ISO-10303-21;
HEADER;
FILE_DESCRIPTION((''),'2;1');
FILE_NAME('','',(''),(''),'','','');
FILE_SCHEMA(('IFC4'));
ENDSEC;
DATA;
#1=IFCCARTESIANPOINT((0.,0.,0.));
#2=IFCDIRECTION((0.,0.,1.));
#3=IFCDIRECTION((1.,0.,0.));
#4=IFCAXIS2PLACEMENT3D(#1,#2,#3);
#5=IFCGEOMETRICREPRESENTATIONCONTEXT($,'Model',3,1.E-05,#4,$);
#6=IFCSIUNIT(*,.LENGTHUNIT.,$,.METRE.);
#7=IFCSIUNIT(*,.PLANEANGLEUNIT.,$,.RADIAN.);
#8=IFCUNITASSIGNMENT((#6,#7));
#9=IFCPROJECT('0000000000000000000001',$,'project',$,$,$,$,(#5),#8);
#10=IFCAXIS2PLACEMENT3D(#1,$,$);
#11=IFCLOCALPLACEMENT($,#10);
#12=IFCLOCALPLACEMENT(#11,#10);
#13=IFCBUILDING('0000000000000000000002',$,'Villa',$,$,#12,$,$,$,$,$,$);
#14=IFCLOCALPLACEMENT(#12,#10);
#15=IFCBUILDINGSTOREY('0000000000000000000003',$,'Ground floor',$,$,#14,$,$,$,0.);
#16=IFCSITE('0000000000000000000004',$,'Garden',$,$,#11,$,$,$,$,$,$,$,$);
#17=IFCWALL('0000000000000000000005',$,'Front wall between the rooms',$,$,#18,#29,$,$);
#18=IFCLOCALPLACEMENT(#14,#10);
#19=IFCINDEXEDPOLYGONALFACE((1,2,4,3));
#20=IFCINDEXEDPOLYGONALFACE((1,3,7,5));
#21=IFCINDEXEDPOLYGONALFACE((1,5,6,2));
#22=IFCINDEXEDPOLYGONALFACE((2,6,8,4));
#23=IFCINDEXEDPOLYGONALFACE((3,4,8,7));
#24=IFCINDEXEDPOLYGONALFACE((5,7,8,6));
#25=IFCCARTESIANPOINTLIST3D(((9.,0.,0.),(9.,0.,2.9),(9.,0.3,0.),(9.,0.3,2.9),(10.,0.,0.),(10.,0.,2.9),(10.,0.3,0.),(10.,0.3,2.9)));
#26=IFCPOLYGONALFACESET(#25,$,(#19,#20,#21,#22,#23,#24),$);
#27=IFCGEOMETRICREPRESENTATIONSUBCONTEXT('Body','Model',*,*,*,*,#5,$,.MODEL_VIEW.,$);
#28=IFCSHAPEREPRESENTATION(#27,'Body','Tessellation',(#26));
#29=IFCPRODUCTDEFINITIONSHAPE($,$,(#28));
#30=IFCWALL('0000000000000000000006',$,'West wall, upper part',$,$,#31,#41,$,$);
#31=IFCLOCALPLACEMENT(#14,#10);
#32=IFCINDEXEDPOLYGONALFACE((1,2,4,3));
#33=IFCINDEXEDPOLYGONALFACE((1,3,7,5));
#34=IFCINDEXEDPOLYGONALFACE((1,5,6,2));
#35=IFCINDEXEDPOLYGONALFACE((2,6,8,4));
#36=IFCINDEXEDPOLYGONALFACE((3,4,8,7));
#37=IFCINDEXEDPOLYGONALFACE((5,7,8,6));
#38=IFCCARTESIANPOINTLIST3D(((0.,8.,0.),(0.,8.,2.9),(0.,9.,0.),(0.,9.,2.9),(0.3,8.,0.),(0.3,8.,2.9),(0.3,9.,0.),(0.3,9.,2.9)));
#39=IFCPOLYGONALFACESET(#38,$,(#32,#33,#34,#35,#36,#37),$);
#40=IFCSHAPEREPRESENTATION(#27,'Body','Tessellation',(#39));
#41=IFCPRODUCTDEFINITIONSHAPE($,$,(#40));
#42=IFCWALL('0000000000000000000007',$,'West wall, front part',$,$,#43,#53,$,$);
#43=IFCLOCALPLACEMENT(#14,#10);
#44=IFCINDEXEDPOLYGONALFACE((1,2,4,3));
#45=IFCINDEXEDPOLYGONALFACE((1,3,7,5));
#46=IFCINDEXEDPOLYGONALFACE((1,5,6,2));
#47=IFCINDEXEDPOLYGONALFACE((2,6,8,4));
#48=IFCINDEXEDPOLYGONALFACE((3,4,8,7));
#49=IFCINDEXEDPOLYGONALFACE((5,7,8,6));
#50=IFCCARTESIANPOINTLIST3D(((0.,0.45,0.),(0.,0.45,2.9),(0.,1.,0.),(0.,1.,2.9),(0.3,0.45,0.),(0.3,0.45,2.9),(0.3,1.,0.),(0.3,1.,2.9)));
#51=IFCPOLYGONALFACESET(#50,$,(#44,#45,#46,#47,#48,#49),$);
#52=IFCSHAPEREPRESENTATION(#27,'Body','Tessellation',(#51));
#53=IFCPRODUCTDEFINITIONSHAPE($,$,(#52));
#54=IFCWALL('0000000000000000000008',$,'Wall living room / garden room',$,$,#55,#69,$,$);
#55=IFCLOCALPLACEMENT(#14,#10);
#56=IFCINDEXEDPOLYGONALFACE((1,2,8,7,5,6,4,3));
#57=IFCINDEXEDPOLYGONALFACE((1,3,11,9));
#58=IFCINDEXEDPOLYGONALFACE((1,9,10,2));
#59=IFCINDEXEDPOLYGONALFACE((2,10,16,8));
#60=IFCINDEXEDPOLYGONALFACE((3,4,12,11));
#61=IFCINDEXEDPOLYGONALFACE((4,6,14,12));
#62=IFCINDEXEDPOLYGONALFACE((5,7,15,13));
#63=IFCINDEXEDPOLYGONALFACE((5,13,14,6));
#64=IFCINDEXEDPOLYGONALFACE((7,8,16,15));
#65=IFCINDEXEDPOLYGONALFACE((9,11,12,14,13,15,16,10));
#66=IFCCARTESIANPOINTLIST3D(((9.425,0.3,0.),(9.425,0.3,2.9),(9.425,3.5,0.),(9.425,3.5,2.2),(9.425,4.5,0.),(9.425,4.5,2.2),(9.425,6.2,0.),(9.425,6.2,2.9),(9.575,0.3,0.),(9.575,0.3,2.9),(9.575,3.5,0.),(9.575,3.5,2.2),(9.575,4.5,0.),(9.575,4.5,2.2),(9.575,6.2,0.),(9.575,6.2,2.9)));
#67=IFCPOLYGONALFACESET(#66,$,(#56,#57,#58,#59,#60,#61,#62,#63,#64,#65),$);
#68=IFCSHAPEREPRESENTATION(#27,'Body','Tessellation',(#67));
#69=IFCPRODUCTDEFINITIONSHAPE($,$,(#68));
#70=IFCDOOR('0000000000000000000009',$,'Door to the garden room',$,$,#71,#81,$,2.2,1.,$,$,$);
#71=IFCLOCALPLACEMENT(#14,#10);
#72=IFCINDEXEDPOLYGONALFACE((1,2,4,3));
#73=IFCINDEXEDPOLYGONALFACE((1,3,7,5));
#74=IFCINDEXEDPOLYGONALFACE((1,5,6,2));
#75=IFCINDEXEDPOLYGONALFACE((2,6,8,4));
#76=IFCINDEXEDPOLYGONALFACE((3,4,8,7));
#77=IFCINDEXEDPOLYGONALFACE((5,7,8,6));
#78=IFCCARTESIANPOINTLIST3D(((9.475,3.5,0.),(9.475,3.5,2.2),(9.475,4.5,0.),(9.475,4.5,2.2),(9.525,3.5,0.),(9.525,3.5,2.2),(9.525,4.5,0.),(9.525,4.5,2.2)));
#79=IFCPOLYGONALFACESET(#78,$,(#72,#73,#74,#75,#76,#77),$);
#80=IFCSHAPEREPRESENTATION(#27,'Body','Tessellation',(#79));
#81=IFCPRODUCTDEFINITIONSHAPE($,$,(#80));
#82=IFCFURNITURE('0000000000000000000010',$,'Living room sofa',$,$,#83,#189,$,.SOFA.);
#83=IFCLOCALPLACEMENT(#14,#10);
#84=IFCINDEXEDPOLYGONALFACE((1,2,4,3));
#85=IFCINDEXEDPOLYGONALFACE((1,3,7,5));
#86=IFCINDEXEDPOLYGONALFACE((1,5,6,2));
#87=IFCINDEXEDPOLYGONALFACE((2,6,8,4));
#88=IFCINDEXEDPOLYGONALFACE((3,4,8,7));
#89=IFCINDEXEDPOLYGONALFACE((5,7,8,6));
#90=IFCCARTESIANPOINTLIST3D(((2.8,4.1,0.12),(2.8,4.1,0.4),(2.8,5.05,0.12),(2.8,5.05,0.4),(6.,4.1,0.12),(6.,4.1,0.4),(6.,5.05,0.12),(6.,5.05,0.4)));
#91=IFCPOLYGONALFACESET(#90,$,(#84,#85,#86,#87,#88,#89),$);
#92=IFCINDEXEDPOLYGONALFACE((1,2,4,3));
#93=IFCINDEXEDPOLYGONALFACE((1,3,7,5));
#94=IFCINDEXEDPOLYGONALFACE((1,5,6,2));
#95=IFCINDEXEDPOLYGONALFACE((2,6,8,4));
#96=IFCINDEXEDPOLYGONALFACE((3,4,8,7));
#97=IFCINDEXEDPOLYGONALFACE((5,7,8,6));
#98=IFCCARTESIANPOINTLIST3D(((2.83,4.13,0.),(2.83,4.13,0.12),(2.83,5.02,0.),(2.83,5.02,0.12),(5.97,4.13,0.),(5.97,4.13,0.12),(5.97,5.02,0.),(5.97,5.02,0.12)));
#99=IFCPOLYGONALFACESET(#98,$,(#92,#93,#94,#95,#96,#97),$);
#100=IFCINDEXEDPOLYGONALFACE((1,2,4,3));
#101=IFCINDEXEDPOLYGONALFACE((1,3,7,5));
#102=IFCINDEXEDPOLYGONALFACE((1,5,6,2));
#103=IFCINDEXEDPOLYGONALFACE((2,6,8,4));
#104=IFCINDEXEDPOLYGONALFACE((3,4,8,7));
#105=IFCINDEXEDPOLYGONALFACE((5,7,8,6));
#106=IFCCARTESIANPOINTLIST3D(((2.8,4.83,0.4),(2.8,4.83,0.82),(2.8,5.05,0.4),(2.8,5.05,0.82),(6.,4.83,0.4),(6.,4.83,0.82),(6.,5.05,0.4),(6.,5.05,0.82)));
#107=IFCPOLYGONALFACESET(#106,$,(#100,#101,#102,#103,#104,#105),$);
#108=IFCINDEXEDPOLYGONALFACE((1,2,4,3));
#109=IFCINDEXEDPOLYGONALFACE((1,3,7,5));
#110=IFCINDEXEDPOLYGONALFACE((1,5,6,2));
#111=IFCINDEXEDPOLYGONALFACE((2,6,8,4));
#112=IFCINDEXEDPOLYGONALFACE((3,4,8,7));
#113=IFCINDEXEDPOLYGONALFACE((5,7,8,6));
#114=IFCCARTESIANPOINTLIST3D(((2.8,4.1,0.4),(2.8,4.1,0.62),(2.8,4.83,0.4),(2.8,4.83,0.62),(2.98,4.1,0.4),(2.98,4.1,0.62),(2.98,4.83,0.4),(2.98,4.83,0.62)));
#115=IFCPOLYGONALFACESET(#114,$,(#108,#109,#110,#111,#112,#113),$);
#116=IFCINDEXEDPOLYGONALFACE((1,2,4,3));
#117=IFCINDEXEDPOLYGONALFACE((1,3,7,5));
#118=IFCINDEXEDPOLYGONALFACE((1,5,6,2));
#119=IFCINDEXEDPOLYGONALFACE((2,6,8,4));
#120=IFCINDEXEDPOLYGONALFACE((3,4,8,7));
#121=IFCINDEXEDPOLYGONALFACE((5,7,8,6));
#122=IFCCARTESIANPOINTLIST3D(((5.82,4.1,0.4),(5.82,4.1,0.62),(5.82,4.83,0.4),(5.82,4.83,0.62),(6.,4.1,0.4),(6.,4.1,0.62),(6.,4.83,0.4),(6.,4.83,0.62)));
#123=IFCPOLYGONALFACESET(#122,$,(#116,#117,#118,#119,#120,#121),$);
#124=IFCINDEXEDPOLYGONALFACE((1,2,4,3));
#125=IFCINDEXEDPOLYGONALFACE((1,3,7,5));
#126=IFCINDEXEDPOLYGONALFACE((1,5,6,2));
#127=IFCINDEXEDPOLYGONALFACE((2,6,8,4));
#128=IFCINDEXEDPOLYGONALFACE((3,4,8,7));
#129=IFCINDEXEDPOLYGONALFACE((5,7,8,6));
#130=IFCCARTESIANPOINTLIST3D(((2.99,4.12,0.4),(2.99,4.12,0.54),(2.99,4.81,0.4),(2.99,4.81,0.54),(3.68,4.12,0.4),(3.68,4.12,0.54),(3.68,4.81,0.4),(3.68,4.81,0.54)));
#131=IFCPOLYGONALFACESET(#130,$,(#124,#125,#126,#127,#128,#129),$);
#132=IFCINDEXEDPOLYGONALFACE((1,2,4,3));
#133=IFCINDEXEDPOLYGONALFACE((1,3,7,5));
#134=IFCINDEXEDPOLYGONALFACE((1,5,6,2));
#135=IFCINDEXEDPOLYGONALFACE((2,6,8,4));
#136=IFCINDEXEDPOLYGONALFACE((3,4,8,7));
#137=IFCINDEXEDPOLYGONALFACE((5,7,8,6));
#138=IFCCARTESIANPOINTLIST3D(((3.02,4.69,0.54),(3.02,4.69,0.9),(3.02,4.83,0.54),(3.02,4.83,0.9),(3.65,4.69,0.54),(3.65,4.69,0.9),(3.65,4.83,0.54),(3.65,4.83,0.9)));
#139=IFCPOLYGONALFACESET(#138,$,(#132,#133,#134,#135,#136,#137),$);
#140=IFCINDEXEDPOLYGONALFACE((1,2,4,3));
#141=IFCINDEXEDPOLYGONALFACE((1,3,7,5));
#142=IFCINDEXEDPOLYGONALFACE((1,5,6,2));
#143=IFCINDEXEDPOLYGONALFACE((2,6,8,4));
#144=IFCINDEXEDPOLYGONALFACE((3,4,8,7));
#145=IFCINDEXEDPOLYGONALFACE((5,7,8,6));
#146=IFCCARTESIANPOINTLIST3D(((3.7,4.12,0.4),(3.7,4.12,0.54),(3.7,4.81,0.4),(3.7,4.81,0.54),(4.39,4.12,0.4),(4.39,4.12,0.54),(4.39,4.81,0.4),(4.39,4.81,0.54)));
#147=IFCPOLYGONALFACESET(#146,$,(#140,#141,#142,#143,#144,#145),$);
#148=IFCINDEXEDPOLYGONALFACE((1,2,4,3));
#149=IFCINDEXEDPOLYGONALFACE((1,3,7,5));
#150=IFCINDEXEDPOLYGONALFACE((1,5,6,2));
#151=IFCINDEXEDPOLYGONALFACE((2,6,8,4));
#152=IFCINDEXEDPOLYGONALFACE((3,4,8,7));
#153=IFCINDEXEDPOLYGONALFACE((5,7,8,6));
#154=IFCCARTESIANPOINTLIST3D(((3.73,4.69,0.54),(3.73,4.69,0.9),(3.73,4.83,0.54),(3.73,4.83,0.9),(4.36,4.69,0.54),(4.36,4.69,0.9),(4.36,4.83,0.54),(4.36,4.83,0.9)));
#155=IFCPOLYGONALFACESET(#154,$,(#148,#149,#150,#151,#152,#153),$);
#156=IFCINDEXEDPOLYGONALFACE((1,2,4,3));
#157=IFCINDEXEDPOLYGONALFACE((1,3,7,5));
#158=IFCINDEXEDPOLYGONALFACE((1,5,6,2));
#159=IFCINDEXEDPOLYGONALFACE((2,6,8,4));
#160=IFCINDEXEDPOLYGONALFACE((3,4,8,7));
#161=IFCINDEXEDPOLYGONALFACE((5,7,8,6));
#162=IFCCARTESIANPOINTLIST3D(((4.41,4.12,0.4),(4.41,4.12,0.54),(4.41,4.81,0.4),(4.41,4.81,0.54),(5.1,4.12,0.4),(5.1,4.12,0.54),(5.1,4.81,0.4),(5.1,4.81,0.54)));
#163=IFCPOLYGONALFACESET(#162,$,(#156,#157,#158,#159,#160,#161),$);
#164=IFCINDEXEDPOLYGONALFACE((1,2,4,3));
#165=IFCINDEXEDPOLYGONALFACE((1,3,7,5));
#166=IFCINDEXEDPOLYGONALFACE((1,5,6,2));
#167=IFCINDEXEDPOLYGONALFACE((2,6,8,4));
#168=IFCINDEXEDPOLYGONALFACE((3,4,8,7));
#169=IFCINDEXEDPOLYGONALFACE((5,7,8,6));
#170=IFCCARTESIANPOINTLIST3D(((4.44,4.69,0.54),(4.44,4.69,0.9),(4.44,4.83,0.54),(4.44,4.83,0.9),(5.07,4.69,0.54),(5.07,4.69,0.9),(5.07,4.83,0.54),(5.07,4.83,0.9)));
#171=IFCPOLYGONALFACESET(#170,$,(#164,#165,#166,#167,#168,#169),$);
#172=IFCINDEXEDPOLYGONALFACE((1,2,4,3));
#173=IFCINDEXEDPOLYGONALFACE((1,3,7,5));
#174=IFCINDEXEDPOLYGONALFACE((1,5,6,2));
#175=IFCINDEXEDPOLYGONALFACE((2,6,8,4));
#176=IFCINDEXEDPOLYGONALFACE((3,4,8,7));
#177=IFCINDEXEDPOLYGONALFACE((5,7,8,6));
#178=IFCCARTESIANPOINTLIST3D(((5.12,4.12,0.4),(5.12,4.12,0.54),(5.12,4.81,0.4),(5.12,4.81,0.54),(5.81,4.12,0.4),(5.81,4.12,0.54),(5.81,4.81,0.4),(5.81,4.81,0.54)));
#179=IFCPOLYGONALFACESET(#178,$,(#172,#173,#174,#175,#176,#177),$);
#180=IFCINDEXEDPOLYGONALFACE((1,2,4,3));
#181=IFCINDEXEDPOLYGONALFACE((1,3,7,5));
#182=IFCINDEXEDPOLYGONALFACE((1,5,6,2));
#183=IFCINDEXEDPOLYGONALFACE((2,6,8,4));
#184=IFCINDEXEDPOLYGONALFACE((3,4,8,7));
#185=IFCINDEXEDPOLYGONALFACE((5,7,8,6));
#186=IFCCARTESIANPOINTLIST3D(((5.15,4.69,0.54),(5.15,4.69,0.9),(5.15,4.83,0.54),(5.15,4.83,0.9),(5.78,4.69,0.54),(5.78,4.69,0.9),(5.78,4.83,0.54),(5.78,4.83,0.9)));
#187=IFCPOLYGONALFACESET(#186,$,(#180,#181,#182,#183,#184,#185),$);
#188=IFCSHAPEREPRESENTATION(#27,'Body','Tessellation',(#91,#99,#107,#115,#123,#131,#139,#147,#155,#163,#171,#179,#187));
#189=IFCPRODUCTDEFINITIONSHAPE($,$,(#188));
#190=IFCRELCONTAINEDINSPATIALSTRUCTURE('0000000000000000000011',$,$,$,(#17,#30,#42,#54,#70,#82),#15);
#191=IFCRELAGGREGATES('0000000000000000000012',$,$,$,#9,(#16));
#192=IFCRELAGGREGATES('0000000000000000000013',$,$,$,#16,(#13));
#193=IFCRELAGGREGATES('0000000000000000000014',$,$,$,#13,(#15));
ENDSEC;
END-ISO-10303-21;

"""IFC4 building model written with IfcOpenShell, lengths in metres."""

from ifc_helpers import new_model, si_unit, frame, frame_2d, origin, origin_with_axes, place, context, subcontext, project, spatial, rectangle, extrude, element, fill, save


model = new_model("IFC4")

# Units and contexts
model_context = context("Model", 3, precision=1e-05, world=origin_with_axes())
body_context = subcontext(model_context, "Body", "Model", "MODEL_VIEW")
ifc_project = project(units=[si_unit("LENGTHUNIT", "METRE"), si_unit("PLANEANGLEUNIT", "RADIAN")], contexts=[model_context])

# Site, building, storey
site_placement = place(None, origin())
site = spatial("IfcSite", under=ifc_project, at=site_placement, Name="Garden")
building_placement = place(site_placement, origin())
building = spatial("IfcBuilding", under=site, at=building_placement, Name="Villa")
storey_placement = place(building_placement, origin())
storey = spatial("IfcBuildingStorey", under=building, at=storey_placement, Name="Ground floor", Elevation=0.0)

# Walls
wall_1_placement = place(storey_placement, frame((9.0, 0.15, 0.0)))
element("IfcWall", 1, at=wall_1_placement, inside=storey, Name="Front wall between the rooms", context=body_context, shape_type="SweptSolid", body=[
    extrude(rectangle(XDim=1.0, YDim=0.3, at=frame_2d((0.5, 0.0))), origin(), (0.0, 0.0, 1.0), 2.9),
])
wall_2_placement = place(storey_placement, frame((0.15, 8.0, 0.0), x_axis=(0.0, 1.0, 0.0)))
element("IfcWall", 2, at=wall_2_placement, inside=storey, Name="West wall, upper part", context=body_context, shape_type="SweptSolid", body=[
    extrude(rectangle(XDim=1.0, YDim=0.3, at=frame_2d((0.5, 0.0))), origin(), (0.0, 0.0, 1.0), 2.9),
])
wall_3_placement = place(storey_placement, frame((0.15, 0.45, 0.0), x_axis=(0.0, 1.0, 0.0)))
element("IfcWall", 3, at=wall_3_placement, inside=storey, Name="West wall, front part", context=body_context, shape_type="SweptSolid", body=[
    extrude(rectangle(XDim=0.55, YDim=0.3, at=frame_2d((0.275, 0.0))), origin(), (0.0, 0.0, 1.0), 2.9),
])

# Wall, opening, door
wall_4_placement = place(storey_placement, frame((9.5, 0.3, 0.0), x_axis=(0.0, 1.0, 0.0)))
wall_4 = element("IfcWall", 4, at=wall_4_placement, inside=storey, Name="Wall living room / garden room", context=body_context, shape_type="SweptSolid", body=[
    extrude(rectangle(XDim=5.9, YDim=0.15, at=frame_2d((2.95, 0.0))), origin(), (0.0, 0.0, 1.0), 2.9),
])
opening_placement = place(wall_4_placement, frame((3.2, 0.0, 0.0)))
opening = element("IfcOpeningElement", 5, at=opening_placement, cuts=wall_4, context=body_context, shape_type="SweptSolid", body=[
    extrude(rectangle(XDim=1.0, YDim=0.25, at=frame_2d((0.5, 0.0))), origin(), (0.0, 0.0, 1.0), 2.2),
])
door_placement = place(opening_placement, origin())
door = element("IfcDoor", 6, at=door_placement, inside=storey, Name="Door to the garden room", OverallHeight=2.2, OverallWidth=1.0, context=body_context, shape_type="SweptSolid", body=[
    extrude(rectangle(XDim=1.0, YDim=0.05, at=frame_2d((0.5, 0.0))), origin(), (0.0, 0.0, 1.0), 2.2),
])
fill(opening, door)

# Furniture
furniture_1_placement = place(storey_placement, frame((2.8, 4.1, 0.0)))
element("IfcFurniture", 7, at=furniture_1_placement, inside=storey, Name="Living room sofa", PredefinedType="SOFA", context=body_context, shape_type="SweptSolid", body=[
    extrude(rectangle(XDim=3.2, YDim=0.95, at=frame_2d((1.6, 0.475))), frame((0.0, 0.0, 0.12)), (0.0, 0.0, 1.0), 0.28),
    extrude(rectangle(XDim=3.14, YDim=0.89, at=frame_2d((1.57, 0.445))), frame((0.03, 0.03, 0.0)), (0.0, 0.0, 1.0), 0.12),
    extrude(rectangle(XDim=3.2, YDim=0.22, at=frame_2d((1.6, 0.11))), frame((0.0, 0.73, 0.4)), (0.0, 0.0, 1.0), 0.42),
    extrude(rectangle(XDim=0.18, YDim=0.73, at=frame_2d((0.09, 0.365))), frame((0.0, 0.0, 0.4)), (0.0, 0.0, 1.0), 0.22),
    extrude(rectangle(XDim=0.18, YDim=0.73, at=frame_2d((0.09, 0.365))), frame((3.02, 0.0, 0.4)), (0.0, 0.0, 1.0), 0.22),
    extrude(rectangle(XDim=0.69, YDim=0.69, at=frame_2d((0.345, 0.345))), frame((0.19, 0.02, 0.4)), (0.0, 0.0, 1.0), 0.14),
    extrude(rectangle(XDim=0.63, YDim=0.14, at=frame_2d((0.315, 0.07))), frame((0.22, 0.59, 0.54)), (0.0, 0.0, 1.0), 0.36),
    extrude(rectangle(XDim=0.69, YDim=0.69, at=frame_2d((0.345, 0.345))), frame((0.9, 0.02, 0.4)), (0.0, 0.0, 1.0), 0.14),
    extrude(rectangle(XDim=0.63, YDim=0.14, at=frame_2d((0.315, 0.07))), frame((0.93, 0.59, 0.54)), (0.0, 0.0, 1.0), 0.36),
    extrude(rectangle(XDim=0.69, YDim=0.69, at=frame_2d((0.345, 0.345))), frame((1.61, 0.02, 0.4)), (0.0, 0.0, 1.0), 0.14),
    extrude(rectangle(XDim=0.63, YDim=0.14, at=frame_2d((0.315, 0.07))), frame((1.64, 0.59, 0.54)), (0.0, 0.0, 1.0), 0.36),
    extrude(rectangle(XDim=0.69, YDim=0.69, at=frame_2d((0.345, 0.345))), frame((2.32, 0.02, 0.4)), (0.0, 0.0, 1.0), 0.14),
    extrude(rectangle(XDim=0.63, YDim=0.14, at=frame_2d((0.315, 0.07))), frame((2.35, 0.59, 0.54)), (0.0, 0.0, 1.0), 0.36),
])

save(model, "model.ifc")
